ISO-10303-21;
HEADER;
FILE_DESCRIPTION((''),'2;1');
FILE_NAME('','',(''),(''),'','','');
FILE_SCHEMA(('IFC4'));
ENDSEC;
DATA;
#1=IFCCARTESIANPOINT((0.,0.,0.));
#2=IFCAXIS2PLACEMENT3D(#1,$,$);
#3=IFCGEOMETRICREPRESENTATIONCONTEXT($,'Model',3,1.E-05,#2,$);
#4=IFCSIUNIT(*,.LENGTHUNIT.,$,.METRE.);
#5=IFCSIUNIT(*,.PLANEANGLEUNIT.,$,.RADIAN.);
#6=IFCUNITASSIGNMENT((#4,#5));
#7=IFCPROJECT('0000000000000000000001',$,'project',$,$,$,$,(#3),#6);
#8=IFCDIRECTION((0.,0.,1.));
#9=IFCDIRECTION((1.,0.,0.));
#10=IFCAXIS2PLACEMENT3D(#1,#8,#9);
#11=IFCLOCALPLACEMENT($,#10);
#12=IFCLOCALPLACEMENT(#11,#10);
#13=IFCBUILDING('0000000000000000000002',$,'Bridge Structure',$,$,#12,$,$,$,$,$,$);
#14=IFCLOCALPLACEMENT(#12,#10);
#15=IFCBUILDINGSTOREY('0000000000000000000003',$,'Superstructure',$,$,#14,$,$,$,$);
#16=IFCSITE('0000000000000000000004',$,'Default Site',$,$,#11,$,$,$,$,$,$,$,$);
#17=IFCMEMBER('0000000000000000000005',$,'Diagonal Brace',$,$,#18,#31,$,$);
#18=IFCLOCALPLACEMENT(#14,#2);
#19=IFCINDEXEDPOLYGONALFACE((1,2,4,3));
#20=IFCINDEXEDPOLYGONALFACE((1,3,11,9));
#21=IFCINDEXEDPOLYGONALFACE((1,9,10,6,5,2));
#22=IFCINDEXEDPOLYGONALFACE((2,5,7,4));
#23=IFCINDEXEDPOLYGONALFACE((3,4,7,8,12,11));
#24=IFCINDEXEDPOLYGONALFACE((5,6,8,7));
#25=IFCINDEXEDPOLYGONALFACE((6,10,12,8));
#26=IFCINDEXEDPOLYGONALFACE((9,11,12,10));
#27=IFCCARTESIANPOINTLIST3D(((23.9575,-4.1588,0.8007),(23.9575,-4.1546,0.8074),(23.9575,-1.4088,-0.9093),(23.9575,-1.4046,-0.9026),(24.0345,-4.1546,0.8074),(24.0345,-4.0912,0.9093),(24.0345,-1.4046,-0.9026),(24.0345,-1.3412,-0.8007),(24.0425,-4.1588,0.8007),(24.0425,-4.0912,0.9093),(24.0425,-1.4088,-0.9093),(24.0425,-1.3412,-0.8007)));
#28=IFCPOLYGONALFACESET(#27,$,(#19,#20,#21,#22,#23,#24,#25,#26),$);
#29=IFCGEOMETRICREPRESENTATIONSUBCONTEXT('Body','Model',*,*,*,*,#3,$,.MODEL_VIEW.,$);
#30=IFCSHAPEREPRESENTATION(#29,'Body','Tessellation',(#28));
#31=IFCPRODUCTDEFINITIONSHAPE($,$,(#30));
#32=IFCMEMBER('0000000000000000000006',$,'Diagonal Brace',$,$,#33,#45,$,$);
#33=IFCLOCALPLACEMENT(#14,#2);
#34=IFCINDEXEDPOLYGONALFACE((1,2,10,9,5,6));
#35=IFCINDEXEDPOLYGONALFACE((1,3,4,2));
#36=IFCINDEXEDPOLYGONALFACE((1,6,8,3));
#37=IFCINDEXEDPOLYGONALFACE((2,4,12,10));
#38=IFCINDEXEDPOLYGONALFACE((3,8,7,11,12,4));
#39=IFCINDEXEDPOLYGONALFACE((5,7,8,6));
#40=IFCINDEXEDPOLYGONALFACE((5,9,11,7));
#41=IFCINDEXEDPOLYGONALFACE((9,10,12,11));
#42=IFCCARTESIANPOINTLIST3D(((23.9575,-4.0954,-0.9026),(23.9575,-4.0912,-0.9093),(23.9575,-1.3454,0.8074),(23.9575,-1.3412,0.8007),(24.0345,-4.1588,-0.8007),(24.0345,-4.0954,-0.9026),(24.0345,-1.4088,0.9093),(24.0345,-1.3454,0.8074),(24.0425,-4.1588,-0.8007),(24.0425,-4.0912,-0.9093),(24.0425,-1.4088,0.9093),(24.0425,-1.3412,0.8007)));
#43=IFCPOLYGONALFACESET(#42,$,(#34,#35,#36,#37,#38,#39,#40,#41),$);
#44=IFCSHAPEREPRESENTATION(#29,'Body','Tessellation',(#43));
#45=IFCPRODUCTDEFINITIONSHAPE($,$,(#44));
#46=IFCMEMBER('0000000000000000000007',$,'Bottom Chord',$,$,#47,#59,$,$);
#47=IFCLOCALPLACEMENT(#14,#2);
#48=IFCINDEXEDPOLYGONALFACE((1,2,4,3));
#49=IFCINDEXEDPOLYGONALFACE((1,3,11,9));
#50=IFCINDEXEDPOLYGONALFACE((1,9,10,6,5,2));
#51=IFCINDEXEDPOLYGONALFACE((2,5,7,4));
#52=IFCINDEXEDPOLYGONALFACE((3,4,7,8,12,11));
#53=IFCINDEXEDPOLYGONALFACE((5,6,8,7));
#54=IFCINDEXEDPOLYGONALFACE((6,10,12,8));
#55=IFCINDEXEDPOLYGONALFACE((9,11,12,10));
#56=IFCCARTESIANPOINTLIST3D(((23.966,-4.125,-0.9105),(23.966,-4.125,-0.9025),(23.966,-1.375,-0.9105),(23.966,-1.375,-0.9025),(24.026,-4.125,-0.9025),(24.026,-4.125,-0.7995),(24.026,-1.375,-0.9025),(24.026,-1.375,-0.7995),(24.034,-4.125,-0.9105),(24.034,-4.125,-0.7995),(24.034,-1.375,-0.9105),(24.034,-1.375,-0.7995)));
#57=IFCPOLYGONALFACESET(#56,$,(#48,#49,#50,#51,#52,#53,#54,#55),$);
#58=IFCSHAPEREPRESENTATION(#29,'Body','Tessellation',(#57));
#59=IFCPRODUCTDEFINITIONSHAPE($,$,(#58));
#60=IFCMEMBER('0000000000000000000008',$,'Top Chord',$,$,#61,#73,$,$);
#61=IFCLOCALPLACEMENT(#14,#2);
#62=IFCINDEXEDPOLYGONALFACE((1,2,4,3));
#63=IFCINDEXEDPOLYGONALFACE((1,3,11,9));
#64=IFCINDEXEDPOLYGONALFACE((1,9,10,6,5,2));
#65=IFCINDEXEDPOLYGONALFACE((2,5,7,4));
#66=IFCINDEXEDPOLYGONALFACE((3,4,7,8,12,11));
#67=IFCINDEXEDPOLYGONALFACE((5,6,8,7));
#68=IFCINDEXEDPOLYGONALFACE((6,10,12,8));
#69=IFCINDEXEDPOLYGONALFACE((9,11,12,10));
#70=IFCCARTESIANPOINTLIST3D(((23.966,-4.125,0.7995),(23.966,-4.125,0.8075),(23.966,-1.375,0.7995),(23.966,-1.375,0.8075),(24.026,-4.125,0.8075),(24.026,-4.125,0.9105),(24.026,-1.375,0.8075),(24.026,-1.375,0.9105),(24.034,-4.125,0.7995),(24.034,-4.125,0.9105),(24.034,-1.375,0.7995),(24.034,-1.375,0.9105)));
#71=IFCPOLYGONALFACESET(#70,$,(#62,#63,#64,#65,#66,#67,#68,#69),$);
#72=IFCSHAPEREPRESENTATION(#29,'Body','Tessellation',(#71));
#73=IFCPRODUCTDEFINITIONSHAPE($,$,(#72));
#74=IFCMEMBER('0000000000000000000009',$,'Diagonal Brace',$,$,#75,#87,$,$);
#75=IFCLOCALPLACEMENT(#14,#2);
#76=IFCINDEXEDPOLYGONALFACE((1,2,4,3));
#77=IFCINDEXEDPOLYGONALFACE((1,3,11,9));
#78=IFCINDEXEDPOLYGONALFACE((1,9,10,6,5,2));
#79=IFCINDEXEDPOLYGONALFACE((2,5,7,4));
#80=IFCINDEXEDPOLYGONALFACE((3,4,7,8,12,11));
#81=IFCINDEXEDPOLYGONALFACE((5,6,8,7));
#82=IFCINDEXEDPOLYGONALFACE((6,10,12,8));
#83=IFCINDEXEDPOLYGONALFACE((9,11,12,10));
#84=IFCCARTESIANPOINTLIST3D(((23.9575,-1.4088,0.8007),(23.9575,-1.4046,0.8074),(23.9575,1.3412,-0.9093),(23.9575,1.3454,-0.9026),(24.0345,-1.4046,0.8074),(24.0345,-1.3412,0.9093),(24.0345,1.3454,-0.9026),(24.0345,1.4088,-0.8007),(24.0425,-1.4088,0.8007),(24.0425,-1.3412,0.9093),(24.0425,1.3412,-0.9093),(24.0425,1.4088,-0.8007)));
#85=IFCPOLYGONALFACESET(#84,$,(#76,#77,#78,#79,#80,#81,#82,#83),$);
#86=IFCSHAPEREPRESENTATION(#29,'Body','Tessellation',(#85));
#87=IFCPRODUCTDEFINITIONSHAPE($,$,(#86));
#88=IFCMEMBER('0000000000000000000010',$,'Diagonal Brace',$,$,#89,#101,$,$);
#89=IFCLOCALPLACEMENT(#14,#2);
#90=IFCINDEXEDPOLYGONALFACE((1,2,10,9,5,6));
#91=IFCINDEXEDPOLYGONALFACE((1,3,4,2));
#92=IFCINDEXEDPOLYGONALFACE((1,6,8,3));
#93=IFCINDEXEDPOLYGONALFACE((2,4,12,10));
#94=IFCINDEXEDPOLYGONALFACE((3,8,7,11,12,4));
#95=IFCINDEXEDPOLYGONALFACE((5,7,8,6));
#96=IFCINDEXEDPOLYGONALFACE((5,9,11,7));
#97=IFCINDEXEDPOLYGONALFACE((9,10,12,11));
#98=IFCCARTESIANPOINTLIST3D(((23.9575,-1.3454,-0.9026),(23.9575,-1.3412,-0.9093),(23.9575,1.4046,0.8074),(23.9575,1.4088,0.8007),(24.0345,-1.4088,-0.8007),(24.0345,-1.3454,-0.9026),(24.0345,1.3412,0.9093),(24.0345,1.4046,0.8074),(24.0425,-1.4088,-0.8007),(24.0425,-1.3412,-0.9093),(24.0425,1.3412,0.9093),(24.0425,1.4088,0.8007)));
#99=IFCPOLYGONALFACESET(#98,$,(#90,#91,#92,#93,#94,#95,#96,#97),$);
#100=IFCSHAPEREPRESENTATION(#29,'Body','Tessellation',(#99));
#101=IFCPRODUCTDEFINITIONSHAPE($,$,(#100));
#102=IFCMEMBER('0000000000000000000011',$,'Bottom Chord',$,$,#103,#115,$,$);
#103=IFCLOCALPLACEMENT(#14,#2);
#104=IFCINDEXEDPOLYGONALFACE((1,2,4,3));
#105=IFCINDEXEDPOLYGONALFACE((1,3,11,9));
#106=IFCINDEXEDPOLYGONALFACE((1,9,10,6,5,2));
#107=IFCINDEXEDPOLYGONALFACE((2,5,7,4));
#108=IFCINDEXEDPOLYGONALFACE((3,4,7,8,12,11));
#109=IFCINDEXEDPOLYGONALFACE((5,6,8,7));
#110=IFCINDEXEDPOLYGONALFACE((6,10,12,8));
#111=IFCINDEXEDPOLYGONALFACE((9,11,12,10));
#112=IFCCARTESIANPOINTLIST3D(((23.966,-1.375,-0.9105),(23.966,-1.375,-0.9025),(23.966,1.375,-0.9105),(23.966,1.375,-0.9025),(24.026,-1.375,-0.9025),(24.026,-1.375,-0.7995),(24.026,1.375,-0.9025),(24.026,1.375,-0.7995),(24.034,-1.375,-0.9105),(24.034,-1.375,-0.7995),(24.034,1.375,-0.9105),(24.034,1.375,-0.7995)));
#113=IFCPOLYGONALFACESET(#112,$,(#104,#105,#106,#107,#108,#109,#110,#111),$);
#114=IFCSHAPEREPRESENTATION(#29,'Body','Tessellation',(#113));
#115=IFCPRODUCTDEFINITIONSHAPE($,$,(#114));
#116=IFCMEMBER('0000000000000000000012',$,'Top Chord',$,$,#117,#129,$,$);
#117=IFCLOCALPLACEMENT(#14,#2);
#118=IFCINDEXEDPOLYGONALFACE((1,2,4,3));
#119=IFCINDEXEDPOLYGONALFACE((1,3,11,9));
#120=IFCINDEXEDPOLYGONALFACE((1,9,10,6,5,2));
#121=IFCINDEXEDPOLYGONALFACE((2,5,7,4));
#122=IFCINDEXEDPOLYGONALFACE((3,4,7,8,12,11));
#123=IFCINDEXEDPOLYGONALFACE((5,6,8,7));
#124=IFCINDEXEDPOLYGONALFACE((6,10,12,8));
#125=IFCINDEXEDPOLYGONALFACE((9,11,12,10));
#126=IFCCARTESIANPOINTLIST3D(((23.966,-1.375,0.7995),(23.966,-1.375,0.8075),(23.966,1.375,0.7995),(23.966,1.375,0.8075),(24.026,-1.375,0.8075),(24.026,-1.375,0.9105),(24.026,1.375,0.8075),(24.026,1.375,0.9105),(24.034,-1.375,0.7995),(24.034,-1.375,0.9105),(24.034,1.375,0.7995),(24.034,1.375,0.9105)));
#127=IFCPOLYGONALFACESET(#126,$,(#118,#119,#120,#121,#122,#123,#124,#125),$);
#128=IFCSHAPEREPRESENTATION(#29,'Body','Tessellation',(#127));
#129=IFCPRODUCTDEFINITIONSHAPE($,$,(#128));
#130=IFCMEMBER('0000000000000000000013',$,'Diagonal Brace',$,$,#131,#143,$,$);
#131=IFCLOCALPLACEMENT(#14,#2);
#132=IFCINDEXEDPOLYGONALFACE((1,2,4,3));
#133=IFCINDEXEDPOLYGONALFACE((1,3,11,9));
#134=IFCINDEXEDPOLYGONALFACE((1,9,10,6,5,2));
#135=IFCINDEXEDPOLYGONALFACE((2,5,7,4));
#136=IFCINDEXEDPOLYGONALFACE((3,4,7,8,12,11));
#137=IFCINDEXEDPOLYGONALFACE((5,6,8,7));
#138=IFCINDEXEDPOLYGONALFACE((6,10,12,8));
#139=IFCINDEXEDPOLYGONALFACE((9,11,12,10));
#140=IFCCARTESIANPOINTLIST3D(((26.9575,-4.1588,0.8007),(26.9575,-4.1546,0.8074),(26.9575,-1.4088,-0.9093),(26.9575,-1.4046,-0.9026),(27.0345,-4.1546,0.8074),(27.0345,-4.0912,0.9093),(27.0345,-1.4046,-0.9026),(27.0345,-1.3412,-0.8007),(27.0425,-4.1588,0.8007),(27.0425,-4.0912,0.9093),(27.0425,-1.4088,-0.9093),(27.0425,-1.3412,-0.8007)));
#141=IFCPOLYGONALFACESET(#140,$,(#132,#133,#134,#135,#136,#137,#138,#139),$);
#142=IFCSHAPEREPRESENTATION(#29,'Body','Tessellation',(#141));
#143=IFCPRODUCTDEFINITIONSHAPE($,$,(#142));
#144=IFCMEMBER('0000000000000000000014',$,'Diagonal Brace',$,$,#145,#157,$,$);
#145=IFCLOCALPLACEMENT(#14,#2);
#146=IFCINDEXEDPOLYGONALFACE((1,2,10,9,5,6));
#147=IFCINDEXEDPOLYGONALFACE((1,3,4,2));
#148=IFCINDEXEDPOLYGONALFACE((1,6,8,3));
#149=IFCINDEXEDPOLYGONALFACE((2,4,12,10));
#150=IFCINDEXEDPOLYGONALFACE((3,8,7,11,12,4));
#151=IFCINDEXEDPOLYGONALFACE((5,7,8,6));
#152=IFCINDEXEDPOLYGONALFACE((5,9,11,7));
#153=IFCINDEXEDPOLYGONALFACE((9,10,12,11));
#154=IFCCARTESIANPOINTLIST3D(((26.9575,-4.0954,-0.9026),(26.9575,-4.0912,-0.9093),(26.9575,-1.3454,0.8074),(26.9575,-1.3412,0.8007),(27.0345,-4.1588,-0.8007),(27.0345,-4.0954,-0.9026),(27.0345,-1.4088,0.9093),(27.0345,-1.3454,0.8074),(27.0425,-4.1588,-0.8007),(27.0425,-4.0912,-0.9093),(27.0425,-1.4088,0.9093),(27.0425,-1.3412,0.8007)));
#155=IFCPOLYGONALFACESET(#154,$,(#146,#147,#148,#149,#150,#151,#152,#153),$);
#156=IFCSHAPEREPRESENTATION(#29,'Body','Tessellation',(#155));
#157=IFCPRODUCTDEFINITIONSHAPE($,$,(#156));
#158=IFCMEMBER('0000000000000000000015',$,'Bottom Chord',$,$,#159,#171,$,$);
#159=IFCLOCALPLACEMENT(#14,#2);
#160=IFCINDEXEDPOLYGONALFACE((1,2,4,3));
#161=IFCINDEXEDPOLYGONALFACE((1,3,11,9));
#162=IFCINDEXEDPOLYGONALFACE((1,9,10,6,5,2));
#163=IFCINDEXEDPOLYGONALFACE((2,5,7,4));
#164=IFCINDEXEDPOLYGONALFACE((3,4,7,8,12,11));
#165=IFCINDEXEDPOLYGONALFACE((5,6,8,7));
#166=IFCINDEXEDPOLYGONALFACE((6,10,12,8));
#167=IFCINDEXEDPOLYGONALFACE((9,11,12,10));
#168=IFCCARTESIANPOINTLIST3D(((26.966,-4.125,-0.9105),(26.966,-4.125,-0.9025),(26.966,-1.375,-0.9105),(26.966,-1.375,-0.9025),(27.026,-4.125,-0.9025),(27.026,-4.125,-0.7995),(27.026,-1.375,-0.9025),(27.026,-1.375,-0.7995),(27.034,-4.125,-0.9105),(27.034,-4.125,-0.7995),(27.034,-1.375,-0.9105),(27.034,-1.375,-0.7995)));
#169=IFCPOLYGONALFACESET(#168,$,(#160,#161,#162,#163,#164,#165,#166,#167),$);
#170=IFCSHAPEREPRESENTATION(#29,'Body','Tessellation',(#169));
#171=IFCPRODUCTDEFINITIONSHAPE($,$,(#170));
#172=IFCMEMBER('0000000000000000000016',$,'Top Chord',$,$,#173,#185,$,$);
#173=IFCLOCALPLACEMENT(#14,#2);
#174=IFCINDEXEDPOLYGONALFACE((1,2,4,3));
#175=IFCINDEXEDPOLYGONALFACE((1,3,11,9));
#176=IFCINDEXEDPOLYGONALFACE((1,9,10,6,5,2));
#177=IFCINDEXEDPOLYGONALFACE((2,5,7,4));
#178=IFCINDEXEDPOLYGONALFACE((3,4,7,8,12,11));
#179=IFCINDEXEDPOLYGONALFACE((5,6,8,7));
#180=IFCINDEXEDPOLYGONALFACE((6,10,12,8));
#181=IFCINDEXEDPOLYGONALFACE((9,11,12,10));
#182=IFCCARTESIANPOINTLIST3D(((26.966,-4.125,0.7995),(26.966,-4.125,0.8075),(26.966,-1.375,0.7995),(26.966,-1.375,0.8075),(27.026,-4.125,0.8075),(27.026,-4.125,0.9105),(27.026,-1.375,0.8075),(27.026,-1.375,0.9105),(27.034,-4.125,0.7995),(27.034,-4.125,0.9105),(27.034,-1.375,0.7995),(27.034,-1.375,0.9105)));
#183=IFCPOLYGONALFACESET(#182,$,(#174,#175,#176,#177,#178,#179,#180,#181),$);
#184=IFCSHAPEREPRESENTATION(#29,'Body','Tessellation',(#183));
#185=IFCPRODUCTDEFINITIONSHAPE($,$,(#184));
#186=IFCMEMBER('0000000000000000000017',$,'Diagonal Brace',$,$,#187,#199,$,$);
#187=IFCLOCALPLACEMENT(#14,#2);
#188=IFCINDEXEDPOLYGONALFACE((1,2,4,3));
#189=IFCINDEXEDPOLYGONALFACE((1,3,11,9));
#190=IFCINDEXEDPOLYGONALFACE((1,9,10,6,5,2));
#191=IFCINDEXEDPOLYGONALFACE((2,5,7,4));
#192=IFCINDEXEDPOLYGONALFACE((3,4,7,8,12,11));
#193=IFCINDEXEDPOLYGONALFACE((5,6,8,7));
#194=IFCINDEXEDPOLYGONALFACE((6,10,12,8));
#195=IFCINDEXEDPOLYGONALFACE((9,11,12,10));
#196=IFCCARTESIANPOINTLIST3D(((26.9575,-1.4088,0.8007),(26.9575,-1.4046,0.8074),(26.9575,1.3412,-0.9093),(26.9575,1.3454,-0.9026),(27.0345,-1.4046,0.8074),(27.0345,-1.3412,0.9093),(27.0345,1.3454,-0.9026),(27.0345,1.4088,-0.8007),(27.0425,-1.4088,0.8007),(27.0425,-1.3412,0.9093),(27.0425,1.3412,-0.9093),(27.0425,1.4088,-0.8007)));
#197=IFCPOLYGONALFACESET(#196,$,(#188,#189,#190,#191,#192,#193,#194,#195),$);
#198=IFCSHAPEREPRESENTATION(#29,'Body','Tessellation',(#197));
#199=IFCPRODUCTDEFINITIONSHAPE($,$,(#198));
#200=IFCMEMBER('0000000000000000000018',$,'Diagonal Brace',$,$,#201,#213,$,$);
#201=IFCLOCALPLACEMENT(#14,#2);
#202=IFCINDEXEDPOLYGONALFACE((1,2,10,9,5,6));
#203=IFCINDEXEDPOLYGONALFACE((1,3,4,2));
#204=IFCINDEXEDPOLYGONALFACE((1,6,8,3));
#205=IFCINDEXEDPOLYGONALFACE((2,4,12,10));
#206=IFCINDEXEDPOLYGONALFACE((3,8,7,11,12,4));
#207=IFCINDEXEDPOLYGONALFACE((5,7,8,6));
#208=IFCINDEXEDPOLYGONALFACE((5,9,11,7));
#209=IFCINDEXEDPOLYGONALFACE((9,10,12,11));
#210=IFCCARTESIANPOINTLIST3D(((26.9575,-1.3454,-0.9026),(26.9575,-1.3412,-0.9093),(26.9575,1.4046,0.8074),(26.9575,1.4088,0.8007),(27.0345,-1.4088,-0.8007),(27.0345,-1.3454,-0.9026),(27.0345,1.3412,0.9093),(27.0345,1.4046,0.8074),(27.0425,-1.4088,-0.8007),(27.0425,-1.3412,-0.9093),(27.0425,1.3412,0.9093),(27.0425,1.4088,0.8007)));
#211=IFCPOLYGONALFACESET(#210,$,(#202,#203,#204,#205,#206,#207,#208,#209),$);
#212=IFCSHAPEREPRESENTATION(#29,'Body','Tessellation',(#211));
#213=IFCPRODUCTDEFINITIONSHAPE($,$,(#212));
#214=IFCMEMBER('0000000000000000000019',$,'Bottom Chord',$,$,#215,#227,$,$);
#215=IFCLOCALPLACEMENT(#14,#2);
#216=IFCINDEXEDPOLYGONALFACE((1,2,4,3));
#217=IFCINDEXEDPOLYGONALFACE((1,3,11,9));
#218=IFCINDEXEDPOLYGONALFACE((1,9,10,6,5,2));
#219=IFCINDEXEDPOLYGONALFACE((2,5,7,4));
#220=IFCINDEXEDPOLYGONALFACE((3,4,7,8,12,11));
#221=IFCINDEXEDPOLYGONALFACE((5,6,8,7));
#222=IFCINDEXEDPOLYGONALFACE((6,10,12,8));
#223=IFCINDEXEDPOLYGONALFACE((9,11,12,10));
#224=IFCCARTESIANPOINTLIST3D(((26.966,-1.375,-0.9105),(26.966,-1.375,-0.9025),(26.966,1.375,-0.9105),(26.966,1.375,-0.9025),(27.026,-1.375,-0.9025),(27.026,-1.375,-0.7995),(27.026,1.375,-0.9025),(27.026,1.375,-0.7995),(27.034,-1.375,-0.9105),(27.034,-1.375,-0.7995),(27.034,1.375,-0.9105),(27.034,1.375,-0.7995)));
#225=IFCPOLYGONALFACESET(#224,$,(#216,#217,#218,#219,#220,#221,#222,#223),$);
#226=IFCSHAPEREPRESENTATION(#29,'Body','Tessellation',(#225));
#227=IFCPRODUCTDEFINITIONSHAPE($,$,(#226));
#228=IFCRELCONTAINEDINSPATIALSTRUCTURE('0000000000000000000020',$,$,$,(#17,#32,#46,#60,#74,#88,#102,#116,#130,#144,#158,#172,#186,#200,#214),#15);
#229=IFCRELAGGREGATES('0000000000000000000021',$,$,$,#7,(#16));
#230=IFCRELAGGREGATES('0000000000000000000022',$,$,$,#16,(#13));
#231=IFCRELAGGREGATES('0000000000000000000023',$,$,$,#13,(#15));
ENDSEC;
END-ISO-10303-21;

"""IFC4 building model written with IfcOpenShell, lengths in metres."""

from ifc_helpers import new_model, si_unit, frame, origin, origin_with_axes, origin_2d_with_axis, place, context, subcontext, project, spatial, l_section, extrude, element, save


model = new_model("IFC4")

# Units and contexts
model_context = context("Model", 3, precision=1e-05, world=origin())
body_context = subcontext(model_context, "Body", "Model", "MODEL_VIEW")
ifc_project = project(units=[si_unit("LENGTHUNIT", "METRE"), si_unit("PLANEANGLEUNIT", "RADIAN")], contexts=[model_context])

# Site, building, storey
site_placement = place(None, origin_with_axes())
site = spatial("IfcSite", under=ifc_project, at=site_placement, Name="Default Site")
building_placement = place(site_placement, origin_with_axes())
building = spatial("IfcBuilding", under=site, at=building_placement, Name="Bridge Structure")
storey_placement = place(building_placement, origin_with_axes())
storey = spatial("IfcBuildingStorey", under=building, at=storey_placement, Name="Superstructure")

# Members
for number, where, z_axis, x_axis, name in (
    (1, (24.0, -4.125, 0.855), (0.0, 0.84921, -0.528055), (-1.0, 0.0, 0.0), "Diagonal Brace"),
    (2, (24.0, -4.125, -0.855), (0.0, 0.84921, 0.528055), (-1.0, 0.0, 0.0), "Diagonal Brace"),
):
    element("IfcMember", number, at=place(storey_placement, frame(where, z_axis=z_axis, x_axis=x_axis)), inside=storey, Name=name, context=body_context, shape_type="SweptSolid", body=[
        extrude(l_section(Depth=0.128, Width=0.085, Thickness=0.008, at=origin_2d_with_axis()), origin_with_axes(), (0.0, 0.0, 1.0), 3.2383),
    ])
for number, where, z_axis, x_axis, name in (
    (3, (24.0, -4.125, -0.855), (0.0, 1.0, 0.0), (-1.0, 0.0, 0.0), "Bottom Chord"),
    (4, (24.0, -4.125, 0.855), (0.0, 1.0, 0.0), (-1.0, 0.0, 0.0), "Top Chord"),
):
    element("IfcMember", number, at=place(storey_placement, frame(where, z_axis=z_axis, x_axis=x_axis)), inside=storey, Name=name, context=body_context, shape_type="SweptSolid", body=[
        extrude(l_section(Depth=0.111, Width=0.068, Thickness=0.008, at=origin_2d_with_axis()), origin_with_axes(), (0.0, 0.0, 1.0), 2.75),
    ])
for number, where, z_axis, x_axis, name in (
    (5, (24.0, -1.375, 0.855), (0.0, 0.84921, -0.528055), (-1.0, 0.0, 0.0), "Diagonal Brace"),
    (6, (24.0, -1.375, -0.855), (0.0, 0.84921, 0.528055), (-1.0, 0.0, 0.0), "Diagonal Brace"),
):
    element("IfcMember", number, at=place(storey_placement, frame(where, z_axis=z_axis, x_axis=x_axis)), inside=storey, Name=name, context=body_context, shape_type="SweptSolid", body=[
        extrude(l_section(Depth=0.128, Width=0.085, Thickness=0.008, at=origin_2d_with_axis()), origin_with_axes(), (0.0, 0.0, 1.0), 3.2383),
    ])
for number, where, z_axis, x_axis, name in (
    (7, (24.0, -1.375, -0.855), (0.0, 1.0, 0.0), (-1.0, 0.0, 0.0), "Bottom Chord"),
    (8, (24.0, -1.375, 0.855), (0.0, 1.0, 0.0), (-1.0, 0.0, 0.0), "Top Chord"),
):
    element("IfcMember", number, at=place(storey_placement, frame(where, z_axis=z_axis, x_axis=x_axis)), inside=storey, Name=name, context=body_context, shape_type="SweptSolid", body=[
        extrude(l_section(Depth=0.111, Width=0.068, Thickness=0.008, at=origin_2d_with_axis()), origin_with_axes(), (0.0, 0.0, 1.0), 2.75),
    ])
for number, where, z_axis, x_axis, name in (
    (9, (27.0, -4.125, 0.855), (0.0, 0.84921, -0.528055), (-1.0, 0.0, 0.0), "Diagonal Brace"),
    (10, (27.0, -4.125, -0.855), (0.0, 0.84921, 0.528055), (-1.0, 0.0, 0.0), "Diagonal Brace"),
):
    element("IfcMember", number, at=place(storey_placement, frame(where, z_axis=z_axis, x_axis=x_axis)), inside=storey, Name=name, context=body_context, shape_type="SweptSolid", body=[
        extrude(l_section(Depth=0.128, Width=0.085, Thickness=0.008, at=origin_2d_with_axis()), origin_with_axes(), (0.0, 0.0, 1.0), 3.2383),
    ])
for number, where, z_axis, x_axis, name in (
    (11, (27.0, -4.125, -0.855), (0.0, 1.0, 0.0), (-1.0, 0.0, 0.0), "Bottom Chord"),
    (12, (27.0, -4.125, 0.855), (0.0, 1.0, 0.0), (-1.0, 0.0, 0.0), "Top Chord"),
):
    element("IfcMember", number, at=place(storey_placement, frame(where, z_axis=z_axis, x_axis=x_axis)), inside=storey, Name=name, context=body_context, shape_type="SweptSolid", body=[
        extrude(l_section(Depth=0.111, Width=0.068, Thickness=0.008, at=origin_2d_with_axis()), origin_with_axes(), (0.0, 0.0, 1.0), 2.75),
    ])
for number, where, z_axis, x_axis, name in (
    (13, (27.0, -1.375, 0.855), (0.0, 0.84921, -0.528055), (-1.0, 0.0, 0.0), "Diagonal Brace"),
    (14, (27.0, -1.375, -0.855), (0.0, 0.84921, 0.528055), (-1.0, 0.0, 0.0), "Diagonal Brace"),
):
    element("IfcMember", number, at=place(storey_placement, frame(where, z_axis=z_axis, x_axis=x_axis)), inside=storey, Name=name, context=body_context, shape_type="SweptSolid", body=[
        extrude(l_section(Depth=0.128, Width=0.085, Thickness=0.008, at=origin_2d_with_axis()), origin_with_axes(), (0.0, 0.0, 1.0), 3.2383),
    ])
for number, where, z_axis, x_axis, name in (
    (15, (27.0, -1.375, -0.855), (0.0, 1.0, 0.0), (-1.0, 0.0, 0.0), "Bottom Chord"),
):
    element("IfcMember", number, at=place(storey_placement, frame(where, z_axis=z_axis, x_axis=x_axis)), inside=storey, Name=name, context=body_context, shape_type="SweptSolid", body=[
        extrude(l_section(Depth=0.111, Width=0.068, Thickness=0.008, at=origin_2d_with_axis()), origin_with_axes(), (0.0, 0.0, 1.0), 2.75),
    ])

save(model, "model.ifc")
